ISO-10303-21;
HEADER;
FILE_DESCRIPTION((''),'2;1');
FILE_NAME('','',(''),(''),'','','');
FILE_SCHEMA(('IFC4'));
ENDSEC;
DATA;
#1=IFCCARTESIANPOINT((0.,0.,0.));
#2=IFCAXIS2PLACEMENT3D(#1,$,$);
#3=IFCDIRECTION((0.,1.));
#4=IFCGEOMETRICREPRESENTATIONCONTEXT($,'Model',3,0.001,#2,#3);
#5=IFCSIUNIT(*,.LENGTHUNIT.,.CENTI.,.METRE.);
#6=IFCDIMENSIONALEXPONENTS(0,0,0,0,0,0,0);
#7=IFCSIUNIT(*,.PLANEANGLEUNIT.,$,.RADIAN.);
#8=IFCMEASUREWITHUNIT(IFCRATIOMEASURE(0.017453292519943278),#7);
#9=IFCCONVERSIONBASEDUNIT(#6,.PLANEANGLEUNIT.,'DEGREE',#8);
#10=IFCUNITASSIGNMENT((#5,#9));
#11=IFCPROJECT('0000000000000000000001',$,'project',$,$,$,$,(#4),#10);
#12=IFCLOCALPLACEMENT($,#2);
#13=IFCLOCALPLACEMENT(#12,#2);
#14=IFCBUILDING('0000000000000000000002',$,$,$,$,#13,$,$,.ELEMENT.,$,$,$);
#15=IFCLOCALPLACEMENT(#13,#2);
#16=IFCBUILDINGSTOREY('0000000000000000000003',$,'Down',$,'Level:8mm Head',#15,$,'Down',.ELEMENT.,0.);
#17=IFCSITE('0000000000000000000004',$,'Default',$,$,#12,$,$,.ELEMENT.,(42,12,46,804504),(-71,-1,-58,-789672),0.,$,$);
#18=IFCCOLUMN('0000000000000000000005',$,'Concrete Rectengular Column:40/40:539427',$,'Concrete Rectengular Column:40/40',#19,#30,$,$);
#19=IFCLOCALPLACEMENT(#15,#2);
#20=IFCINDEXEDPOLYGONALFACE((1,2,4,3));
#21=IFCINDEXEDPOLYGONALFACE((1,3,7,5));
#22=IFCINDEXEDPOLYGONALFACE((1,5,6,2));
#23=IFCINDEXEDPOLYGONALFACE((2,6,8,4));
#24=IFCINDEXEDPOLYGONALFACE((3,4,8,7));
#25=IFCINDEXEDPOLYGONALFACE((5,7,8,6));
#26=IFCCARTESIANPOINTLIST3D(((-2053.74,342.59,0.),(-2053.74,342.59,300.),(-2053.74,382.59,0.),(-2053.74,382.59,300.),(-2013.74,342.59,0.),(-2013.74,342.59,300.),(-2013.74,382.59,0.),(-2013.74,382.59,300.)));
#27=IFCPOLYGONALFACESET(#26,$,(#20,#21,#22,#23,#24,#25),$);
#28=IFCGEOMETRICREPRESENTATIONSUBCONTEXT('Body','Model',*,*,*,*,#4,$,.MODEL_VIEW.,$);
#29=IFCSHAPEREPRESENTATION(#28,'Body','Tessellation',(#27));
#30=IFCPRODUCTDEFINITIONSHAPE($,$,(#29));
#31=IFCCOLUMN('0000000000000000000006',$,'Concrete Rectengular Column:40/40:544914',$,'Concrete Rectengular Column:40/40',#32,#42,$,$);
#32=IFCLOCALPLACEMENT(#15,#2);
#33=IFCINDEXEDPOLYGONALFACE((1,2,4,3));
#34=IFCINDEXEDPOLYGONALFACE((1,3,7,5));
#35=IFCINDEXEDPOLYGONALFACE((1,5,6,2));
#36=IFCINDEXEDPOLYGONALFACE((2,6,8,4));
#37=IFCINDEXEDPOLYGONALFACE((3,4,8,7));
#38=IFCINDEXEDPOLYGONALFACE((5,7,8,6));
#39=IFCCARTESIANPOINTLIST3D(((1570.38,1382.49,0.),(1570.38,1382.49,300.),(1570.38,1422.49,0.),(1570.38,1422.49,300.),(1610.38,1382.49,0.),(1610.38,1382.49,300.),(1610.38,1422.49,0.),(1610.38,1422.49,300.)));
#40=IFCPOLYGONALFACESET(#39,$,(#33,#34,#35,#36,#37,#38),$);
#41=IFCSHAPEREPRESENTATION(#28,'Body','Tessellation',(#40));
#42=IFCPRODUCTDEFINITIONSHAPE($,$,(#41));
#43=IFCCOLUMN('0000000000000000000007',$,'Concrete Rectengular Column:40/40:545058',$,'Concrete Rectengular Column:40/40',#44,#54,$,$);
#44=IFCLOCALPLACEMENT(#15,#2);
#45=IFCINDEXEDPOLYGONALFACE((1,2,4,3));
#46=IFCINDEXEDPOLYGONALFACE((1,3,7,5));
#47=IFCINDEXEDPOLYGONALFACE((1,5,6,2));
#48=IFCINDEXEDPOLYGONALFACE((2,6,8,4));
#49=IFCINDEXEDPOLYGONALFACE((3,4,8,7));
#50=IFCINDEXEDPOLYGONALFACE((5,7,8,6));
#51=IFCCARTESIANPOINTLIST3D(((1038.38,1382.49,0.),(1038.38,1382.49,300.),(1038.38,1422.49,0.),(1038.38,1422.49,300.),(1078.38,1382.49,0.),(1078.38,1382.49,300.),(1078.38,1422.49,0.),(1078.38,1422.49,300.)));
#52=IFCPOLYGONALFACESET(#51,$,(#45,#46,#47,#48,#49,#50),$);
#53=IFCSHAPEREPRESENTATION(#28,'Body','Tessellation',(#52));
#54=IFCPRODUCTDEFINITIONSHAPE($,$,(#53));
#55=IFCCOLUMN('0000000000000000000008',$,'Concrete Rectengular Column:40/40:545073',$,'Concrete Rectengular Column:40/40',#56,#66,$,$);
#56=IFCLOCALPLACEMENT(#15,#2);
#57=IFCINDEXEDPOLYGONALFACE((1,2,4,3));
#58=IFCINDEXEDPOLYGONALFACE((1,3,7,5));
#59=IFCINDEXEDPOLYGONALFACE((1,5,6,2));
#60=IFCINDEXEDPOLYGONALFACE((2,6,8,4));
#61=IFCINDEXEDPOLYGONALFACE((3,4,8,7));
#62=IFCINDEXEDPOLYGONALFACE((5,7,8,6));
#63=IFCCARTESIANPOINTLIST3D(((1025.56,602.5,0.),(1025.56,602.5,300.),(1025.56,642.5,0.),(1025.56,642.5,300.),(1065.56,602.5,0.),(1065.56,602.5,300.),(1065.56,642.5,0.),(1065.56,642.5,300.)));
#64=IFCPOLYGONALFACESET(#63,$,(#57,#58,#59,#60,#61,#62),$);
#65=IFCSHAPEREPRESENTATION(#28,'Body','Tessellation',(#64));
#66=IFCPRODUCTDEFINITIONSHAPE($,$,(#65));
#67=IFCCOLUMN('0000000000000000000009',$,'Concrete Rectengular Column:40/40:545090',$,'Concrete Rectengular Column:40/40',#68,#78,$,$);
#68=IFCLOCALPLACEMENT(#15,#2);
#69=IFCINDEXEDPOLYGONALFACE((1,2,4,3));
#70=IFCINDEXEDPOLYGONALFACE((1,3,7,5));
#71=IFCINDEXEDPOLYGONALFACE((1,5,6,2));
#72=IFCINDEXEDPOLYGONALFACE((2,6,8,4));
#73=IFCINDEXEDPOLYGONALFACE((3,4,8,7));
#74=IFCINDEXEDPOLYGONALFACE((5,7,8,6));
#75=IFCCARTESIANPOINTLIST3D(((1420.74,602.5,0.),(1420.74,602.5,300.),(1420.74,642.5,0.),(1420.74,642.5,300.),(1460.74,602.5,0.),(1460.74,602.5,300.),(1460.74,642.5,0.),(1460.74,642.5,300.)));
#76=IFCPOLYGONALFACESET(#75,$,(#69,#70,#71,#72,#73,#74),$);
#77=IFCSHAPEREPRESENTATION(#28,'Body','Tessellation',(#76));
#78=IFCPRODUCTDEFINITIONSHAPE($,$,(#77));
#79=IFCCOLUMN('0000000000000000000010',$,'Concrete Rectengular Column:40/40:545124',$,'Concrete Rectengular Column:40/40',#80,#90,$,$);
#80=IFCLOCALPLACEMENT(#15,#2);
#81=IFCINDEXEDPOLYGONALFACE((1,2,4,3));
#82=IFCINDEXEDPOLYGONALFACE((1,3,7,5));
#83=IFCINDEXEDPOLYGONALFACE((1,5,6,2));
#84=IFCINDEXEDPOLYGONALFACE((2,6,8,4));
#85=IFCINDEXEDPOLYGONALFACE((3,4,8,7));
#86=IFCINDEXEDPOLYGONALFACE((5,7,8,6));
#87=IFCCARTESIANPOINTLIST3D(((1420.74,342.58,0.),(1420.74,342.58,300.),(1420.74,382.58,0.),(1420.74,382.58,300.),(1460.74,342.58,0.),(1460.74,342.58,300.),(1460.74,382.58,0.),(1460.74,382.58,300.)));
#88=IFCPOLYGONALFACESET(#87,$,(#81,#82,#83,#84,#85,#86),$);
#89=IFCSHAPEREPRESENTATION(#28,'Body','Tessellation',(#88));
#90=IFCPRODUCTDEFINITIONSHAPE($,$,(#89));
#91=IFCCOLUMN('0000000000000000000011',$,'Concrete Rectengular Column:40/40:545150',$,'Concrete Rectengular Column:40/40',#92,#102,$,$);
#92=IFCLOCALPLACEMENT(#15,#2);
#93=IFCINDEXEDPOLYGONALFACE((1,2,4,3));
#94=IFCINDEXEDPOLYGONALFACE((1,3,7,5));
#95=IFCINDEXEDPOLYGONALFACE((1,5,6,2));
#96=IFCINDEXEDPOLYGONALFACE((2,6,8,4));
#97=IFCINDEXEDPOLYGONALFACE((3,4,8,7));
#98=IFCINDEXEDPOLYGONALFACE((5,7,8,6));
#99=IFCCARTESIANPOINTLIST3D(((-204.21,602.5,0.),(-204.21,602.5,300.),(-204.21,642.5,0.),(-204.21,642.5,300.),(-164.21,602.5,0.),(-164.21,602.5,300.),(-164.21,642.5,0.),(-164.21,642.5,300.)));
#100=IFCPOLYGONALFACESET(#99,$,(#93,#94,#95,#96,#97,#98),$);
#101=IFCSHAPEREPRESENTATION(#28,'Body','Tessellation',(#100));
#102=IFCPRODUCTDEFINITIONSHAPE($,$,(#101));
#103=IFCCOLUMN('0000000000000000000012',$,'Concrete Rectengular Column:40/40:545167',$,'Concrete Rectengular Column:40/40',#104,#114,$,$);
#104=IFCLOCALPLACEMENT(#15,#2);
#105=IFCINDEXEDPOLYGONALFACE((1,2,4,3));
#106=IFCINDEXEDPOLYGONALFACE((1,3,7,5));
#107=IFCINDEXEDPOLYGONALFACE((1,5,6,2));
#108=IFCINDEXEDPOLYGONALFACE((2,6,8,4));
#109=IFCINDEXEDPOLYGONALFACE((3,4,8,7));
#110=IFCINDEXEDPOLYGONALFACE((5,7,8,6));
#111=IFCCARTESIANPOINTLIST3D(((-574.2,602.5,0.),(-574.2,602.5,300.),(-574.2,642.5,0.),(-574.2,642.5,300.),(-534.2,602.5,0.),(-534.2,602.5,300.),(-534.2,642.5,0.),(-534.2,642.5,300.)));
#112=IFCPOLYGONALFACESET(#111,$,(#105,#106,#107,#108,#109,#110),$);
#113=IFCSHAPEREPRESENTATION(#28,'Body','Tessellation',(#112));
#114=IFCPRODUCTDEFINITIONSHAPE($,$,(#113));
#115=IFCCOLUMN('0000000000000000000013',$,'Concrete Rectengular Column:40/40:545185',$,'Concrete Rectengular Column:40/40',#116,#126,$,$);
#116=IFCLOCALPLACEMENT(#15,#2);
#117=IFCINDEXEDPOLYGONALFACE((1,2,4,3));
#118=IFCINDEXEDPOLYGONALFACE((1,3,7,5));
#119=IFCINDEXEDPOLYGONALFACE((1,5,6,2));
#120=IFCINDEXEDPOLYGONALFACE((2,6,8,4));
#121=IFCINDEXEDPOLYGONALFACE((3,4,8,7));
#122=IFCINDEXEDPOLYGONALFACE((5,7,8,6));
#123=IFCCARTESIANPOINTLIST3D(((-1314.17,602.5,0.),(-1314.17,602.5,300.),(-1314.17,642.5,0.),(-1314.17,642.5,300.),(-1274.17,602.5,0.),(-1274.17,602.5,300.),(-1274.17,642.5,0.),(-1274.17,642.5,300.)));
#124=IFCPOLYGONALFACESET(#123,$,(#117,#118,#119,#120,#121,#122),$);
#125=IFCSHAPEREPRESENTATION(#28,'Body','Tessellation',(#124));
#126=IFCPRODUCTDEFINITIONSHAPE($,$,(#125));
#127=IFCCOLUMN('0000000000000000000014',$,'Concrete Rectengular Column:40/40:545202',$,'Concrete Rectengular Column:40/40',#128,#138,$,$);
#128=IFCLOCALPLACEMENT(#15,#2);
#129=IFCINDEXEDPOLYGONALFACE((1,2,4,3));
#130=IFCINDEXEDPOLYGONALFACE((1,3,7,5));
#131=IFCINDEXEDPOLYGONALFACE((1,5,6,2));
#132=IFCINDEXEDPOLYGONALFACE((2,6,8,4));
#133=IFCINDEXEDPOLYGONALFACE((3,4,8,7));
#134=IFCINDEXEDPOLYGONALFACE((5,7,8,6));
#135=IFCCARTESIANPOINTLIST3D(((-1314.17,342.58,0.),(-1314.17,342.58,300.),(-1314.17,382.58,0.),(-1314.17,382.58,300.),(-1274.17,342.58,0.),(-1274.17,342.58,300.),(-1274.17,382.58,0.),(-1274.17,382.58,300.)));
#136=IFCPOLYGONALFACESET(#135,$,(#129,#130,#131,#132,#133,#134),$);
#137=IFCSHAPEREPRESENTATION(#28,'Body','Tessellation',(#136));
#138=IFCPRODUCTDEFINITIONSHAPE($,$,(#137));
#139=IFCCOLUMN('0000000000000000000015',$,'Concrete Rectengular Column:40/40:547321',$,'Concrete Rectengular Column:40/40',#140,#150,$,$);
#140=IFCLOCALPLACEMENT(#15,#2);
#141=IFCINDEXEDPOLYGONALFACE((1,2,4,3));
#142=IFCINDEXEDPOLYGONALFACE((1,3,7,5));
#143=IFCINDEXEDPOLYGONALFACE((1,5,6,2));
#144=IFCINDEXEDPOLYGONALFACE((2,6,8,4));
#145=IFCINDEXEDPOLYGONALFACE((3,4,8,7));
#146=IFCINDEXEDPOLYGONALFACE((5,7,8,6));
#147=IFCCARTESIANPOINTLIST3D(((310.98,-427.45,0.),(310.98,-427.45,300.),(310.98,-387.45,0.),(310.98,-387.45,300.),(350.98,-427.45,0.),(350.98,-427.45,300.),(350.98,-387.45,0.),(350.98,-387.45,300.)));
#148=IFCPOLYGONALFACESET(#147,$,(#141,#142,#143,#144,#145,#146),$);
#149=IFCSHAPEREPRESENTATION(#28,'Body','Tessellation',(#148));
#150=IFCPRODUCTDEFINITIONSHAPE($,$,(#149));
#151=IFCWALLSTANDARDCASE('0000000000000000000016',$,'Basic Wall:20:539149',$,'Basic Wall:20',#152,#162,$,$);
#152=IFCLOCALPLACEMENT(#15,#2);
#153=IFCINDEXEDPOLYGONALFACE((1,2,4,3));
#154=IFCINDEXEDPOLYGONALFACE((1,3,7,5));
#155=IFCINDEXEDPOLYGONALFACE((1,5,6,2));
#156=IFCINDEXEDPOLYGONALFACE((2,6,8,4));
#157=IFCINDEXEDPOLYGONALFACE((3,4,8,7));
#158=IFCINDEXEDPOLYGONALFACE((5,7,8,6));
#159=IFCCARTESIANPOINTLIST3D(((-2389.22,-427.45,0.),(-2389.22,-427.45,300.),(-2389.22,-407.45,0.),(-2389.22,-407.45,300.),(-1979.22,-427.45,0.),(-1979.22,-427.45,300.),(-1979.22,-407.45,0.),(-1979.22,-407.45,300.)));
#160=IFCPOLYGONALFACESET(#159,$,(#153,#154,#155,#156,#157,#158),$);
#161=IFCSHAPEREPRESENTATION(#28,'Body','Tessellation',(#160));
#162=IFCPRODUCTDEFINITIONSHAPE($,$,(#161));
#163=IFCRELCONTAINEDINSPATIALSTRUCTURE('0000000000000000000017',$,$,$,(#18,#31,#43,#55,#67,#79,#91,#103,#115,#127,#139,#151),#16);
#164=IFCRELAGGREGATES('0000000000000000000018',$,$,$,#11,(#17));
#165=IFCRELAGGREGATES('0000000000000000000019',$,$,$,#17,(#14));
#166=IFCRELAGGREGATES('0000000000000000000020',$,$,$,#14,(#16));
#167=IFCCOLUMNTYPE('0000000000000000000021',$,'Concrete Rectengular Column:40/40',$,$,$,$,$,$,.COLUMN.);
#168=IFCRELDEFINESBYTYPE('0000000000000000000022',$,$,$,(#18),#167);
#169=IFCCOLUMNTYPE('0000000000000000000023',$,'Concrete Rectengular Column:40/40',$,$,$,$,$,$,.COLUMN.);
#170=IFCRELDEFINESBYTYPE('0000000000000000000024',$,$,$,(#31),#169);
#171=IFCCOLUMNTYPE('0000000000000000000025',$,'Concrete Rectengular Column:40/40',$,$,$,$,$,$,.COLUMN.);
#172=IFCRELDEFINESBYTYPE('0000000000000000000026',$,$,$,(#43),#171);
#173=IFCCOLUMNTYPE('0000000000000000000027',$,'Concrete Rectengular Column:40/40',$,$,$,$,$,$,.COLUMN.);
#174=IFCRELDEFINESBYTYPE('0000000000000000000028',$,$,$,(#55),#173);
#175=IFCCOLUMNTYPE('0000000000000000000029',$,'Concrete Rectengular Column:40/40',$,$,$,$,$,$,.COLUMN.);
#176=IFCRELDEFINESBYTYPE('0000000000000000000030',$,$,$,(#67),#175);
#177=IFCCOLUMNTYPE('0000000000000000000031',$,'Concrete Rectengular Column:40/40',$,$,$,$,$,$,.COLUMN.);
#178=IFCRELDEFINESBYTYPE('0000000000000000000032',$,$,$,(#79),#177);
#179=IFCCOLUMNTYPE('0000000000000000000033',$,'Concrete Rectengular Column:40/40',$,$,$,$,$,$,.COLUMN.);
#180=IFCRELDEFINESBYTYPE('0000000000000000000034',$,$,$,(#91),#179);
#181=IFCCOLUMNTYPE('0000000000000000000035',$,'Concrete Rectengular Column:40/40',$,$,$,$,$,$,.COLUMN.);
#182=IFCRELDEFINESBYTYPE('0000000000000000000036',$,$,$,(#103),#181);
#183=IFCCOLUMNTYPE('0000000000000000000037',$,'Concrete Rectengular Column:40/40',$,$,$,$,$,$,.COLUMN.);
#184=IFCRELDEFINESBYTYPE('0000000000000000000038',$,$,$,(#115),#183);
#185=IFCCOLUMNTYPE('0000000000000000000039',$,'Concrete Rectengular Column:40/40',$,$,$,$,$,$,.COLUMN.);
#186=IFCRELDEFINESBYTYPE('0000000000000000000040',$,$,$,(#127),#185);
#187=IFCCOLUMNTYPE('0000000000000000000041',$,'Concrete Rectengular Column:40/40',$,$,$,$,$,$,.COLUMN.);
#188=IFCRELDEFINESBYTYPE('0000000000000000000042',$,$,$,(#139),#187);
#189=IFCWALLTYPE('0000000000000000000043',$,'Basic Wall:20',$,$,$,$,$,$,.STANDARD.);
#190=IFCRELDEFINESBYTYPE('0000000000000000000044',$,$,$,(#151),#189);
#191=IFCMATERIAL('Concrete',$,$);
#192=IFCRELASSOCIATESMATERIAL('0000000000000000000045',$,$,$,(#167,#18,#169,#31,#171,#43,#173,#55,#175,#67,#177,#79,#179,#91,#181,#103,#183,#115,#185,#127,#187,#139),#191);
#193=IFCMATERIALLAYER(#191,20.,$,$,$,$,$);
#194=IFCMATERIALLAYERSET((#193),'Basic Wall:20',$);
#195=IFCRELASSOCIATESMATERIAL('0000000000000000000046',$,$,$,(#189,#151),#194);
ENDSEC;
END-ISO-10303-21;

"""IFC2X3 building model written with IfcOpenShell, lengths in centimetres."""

from ifc_helpers import new_model, entity, si_unit, converted_unit, direction, frame, frame_2d, origin, origin_2d_with_axis, place, context, subcontext, project, spatial, rectangle, extrude, source, transform, mapped, material, layer, layer_set, layer_usage, type_object, type_shapes, element, save


model = new_model("IFC2X3")

# Units and contexts
model_context = context("Model", 3, precision=0.001, world=origin(), true_north=direction((0.0, 1.0)))
body_context = subcontext(model_context, "Body", "Model", "MODEL_VIEW")
ifc_project = project(units=[si_unit("LENGTHUNIT", "METRE", prefix="CENTI"), converted_unit("PLANEANGLEUNIT", "DEGREE", entity("IfcRatioMeasure", 0.017453292519943278), si_unit("PLANEANGLEUNIT", "RADIAN"), dimensions=[0, 0, 0, 0, 0, 0, 0])], contexts=[model_context])

# Site, building, storey
site_placement = place(None, origin())
site = spatial("IfcSite", under=ifc_project, at=site_placement, Name="Default", CompositionType="ELEMENT", RefLatitude=(42, 12, 46, 804504), RefLongitude=(-71, -1, -58, -789672), RefElevation=0.0)
building_placement = place(site_placement, origin())
building = spatial("IfcBuilding", under=site, at=building_placement, CompositionType="ELEMENT")
storey_placement = place(building_placement, origin())
storey = spatial("IfcBuildingStorey", under=building, at=storey_placement, Name="Down", ObjectType="Level:8mm Head", LongName="Down", CompositionType="ELEMENT", Elevation=0.0)

# Columns
ifc_material = material(Name="Concrete")
column_type_1 = type_object("IfcColumnType", Name="Concrete Rectengular Column:40/40", PredefinedType="COLUMN", material=ifc_material)
shared_shape_1 = source(origin(), body_context, "Body", "SweptSolid", [
    extrude(rectangle(XDim=40.0, YDim=40.0, at=frame_2d((0.0, 0.0), x_axis=(1.0, 0.0))), frame((-2033.74, 362.59, 0.0), z_axis=(0.0, 0.0, 1.0), x_axis=(0.0, -1.0, 0.0)), (0.0, 0.0, 1.0), 300.0),
])
type_shapes(column_type_1, [shared_shape_1])
column_1_placement = place(storey_placement, origin())
element("IfcColumn", 1, at=column_1_placement, inside=storey, type_object=column_type_1, material=ifc_material, Name="Concrete Rectengular Column:40/40:539427", ObjectType="Concrete Rectengular Column:40/40", context=body_context, shape_type="MappedRepresentation", body=[
    mapped(shared_shape_1, transform((0.0, 0.0, 0.0), scale=1.0)),
])
column_type_2 = type_object("IfcColumnType", Name="Concrete Rectengular Column:40/40", PredefinedType="COLUMN", material=ifc_material)
shared_shape_2 = source(origin(), body_context, "Body", "SweptSolid", [
    extrude(rectangle(XDim=40.0, YDim=40.0, at=origin_2d_with_axis()), frame((1590.38, 1402.49, 0.0), z_axis=(0.0, 0.0, 1.0), x_axis=(0.0, -1.0, 0.0)), (0.0, 0.0, 1.0), 300.0),
])
type_shapes(column_type_2, [shared_shape_2])
column_2_placement = place(storey_placement, origin())
element("IfcColumn", 2, at=column_2_placement, inside=storey, type_object=column_type_2, material=ifc_material, Name="Concrete Rectengular Column:40/40:544914", ObjectType="Concrete Rectengular Column:40/40", context=body_context, shape_type="MappedRepresentation", body=[
    mapped(shared_shape_2, transform((0.0, 0.0, 0.0), scale=1.0)),
])
column_type_3 = type_object("IfcColumnType", Name="Concrete Rectengular Column:40/40", PredefinedType="COLUMN", material=ifc_material)
shared_shape_3 = source(origin(), body_context, "Body", "SweptSolid", [
    extrude(rectangle(XDim=40.0, YDim=40.0, at=origin_2d_with_axis()), frame((1058.38, 1402.49, 0.0), z_axis=(0.0, 0.0, 1.0), x_axis=(0.0, -1.0, 0.0)), (0.0, 0.0, 1.0), 300.0),
])
type_shapes(column_type_3, [shared_shape_3])
column_3_placement = place(storey_placement, origin())
element("IfcColumn", 3, at=column_3_placement, inside=storey, type_object=column_type_3, material=ifc_material, Name="Concrete Rectengular Column:40/40:545058", ObjectType="Concrete Rectengular Column:40/40", context=body_context, shape_type="MappedRepresentation", body=[
    mapped(shared_shape_3, transform((0.0, 0.0, 0.0), scale=1.0)),
])
column_type_4 = type_object("IfcColumnType", Name="Concrete Rectengular Column:40/40", PredefinedType="COLUMN", material=ifc_material)
shared_shape_4 = source(origin(), body_context, "Body", "SweptSolid", [
    extrude(rectangle(XDim=40.0, YDim=40.0, at=origin_2d_with_axis()), frame((1045.56, 622.5, 0.0), z_axis=(0.0, 0.0, 1.0), x_axis=(0.0, -1.0, 0.0)), (0.0, 0.0, 1.0), 300.0),
])
type_shapes(column_type_4, [shared_shape_4])
column_4_placement = place(storey_placement, origin())
element("IfcColumn", 4, at=column_4_placement, inside=storey, type_object=column_type_4, material=ifc_material, Name="Concrete Rectengular Column:40/40:545073", ObjectType="Concrete Rectengular Column:40/40", context=body_context, shape_type="MappedRepresentation", body=[
    mapped(shared_shape_4, transform((0.0, 0.0, 0.0), scale=1.0)),
])
column_type_5 = type_object("IfcColumnType", Name="Concrete Rectengular Column:40/40", PredefinedType="COLUMN", material=ifc_material)
shared_shape_5 = source(origin(), body_context, "Body", "SweptSolid", [
    extrude(rectangle(XDim=40.0, YDim=40.0, at=origin_2d_with_axis()), frame((1440.74, 622.5, 0.0), z_axis=(0.0, 0.0, 1.0), x_axis=(0.0, -1.0, 0.0)), (0.0, 0.0, 1.0), 300.0),
])
type_shapes(column_type_5, [shared_shape_5])
column_5_placement = place(storey_placement, origin())
element("IfcColumn", 5, at=column_5_placement, inside=storey, type_object=column_type_5, material=ifc_material, Name="Concrete Rectengular Column:40/40:545090", ObjectType="Concrete Rectengular Column:40/40", context=body_context, shape_type="MappedRepresentation", body=[
    mapped(shared_shape_5, transform((0.0, 0.0, 0.0), scale=1.0)),
])
column_type_6 = type_object("IfcColumnType", Name="Concrete Rectengular Column:40/40", PredefinedType="COLUMN", material=ifc_material)
shared_shape_6 = source(origin(), body_context, "Body", "SweptSolid", [
    extrude(rectangle(XDim=40.0, YDim=40.0, at=frame_2d((0.0, 0.0), x_axis=(1.0, 0.0))), frame((1440.74, 362.58, 0.0), z_axis=(0.0, 0.0, 1.0), x_axis=(0.0, -1.0, 0.0)), (0.0, 0.0, 1.0), 300.0),
])
type_shapes(column_type_6, [shared_shape_6])
column_6_placement = place(storey_placement, origin())
element("IfcColumn", 6, at=column_6_placement, inside=storey, type_object=column_type_6, material=ifc_material, Name="Concrete Rectengular Column:40/40:545124", ObjectType="Concrete Rectengular Column:40/40", context=body_context, shape_type="MappedRepresentation", body=[
    mapped(shared_shape_6, transform((0.0, 0.0, 0.0), scale=1.0)),
])
column_type_7 = type_object("IfcColumnType", Name="Concrete Rectengular Column:40/40", PredefinedType="COLUMN", material=ifc_material)
shared_shape_7 = source(origin(), body_context, "Body", "SweptSolid", [
    extrude(rectangle(XDim=40.0, YDim=40.0, at=frame_2d((0.0, 0.0), x_axis=(1.0, 0.0))), frame((-184.21, 622.5, 0.0), z_axis=(0.0, 0.0, 1.0), x_axis=(0.0, -1.0, 0.0)), (0.0, 0.0, 1.0), 300.0),
])
type_shapes(column_type_7, [shared_shape_7])
column_7_placement = place(storey_placement, origin())
element("IfcColumn", 7, at=column_7_placement, inside=storey, type_object=column_type_7, material=ifc_material, Name="Concrete Rectengular Column:40/40:545150", ObjectType="Concrete Rectengular Column:40/40", context=body_context, shape_type="MappedRepresentation", body=[
    mapped(shared_shape_7, transform((0.0, 0.0, 0.0), scale=1.0)),
])
column_type_8 = type_object("IfcColumnType", Name="Concrete Rectengular Column:40/40", PredefinedType="COLUMN", material=ifc_material)
shared_shape_8 = source(origin(), body_context, "Body", "SweptSolid", [
    extrude(rectangle(XDim=40.0, YDim=40.0, at=origin_2d_with_axis()), frame((-554.2, 622.5, 0.0), z_axis=(0.0, 0.0, 1.0), x_axis=(0.0, -1.0, 0.0)), (0.0, 0.0, 1.0), 300.0),
])
type_shapes(column_type_8, [shared_shape_8])
column_8_placement = place(storey_placement, origin())
element("IfcColumn", 8, at=column_8_placement, inside=storey, type_object=column_type_8, material=ifc_material, Name="Concrete Rectengular Column:40/40:545167", ObjectType="Concrete Rectengular Column:40/40", context=body_context, shape_type="MappedRepresentation", body=[
    mapped(shared_shape_8, transform((0.0, 0.0, 0.0), scale=1.0)),
])
column_type_9 = type_object("IfcColumnType", Name="Concrete Rectengular Column:40/40", PredefinedType="COLUMN", material=ifc_material)
shared_shape_9 = source(origin(), body_context, "Body", "SweptSolid", [
    extrude(rectangle(XDim=40.0, YDim=40.0, at=origin_2d_with_axis()), frame((-1294.17, 622.5, 0.0), z_axis=(0.0, 0.0, 1.0), x_axis=(0.0, -1.0, 0.0)), (0.0, 0.0, 1.0), 300.0),
])
type_shapes(column_type_9, [shared_shape_9])
column_9_placement = place(storey_placement, origin())
element("IfcColumn", 9, at=column_9_placement, inside=storey, type_object=column_type_9, material=ifc_material, Name="Concrete Rectengular Column:40/40:545185", ObjectType="Concrete Rectengular Column:40/40", context=body_context, shape_type="MappedRepresentation", body=[
    mapped(shared_shape_9, transform((0.0, 0.0, 0.0), scale=1.0)),
])
column_type_10 = type_object("IfcColumnType", Name="Concrete Rectengular Column:40/40", PredefinedType="COLUMN", material=ifc_material)
shared_shape_10 = source(origin(), body_context, "Body", "SweptSolid", [
    extrude(rectangle(XDim=40.0, YDim=40.0, at=origin_2d_with_axis()), frame((-1294.17, 362.58, 0.0), z_axis=(0.0, 0.0, 1.0), x_axis=(0.0, -1.0, 0.0)), (0.0, 0.0, 1.0), 300.0),
])
type_shapes(column_type_10, [shared_shape_10])
column_10_placement = place(storey_placement, origin())
element("IfcColumn", 10, at=column_10_placement, inside=storey, type_object=column_type_10, material=ifc_material, Name="Concrete Rectengular Column:40/40:545202", ObjectType="Concrete Rectengular Column:40/40", context=body_context, shape_type="MappedRepresentation", body=[
    mapped(shared_shape_10, transform((0.0, 0.0, 0.0), scale=1.0)),
])
column_type_11 = type_object("IfcColumnType", Name="Concrete Rectengular Column:40/40", PredefinedType="COLUMN", material=ifc_material)
shared_shape_11 = source(origin(), body_context, "Body", "SweptSolid", [
    extrude(rectangle(XDim=40.0, YDim=40.0, at=origin_2d_with_axis()), frame((330.98, -407.45, 0.0), z_axis=(0.0, 0.0, 1.0), x_axis=(0.0, -1.0, 0.0)), (0.0, 0.0, 1.0), 300.0),
])
type_shapes(column_type_11, [shared_shape_11])
column_11_placement = place(storey_placement, origin())
element("IfcColumn", 11, at=column_11_placement, inside=storey, type_object=column_type_11, material=ifc_material, Name="Concrete Rectengular Column:40/40:547321", ObjectType="Concrete Rectengular Column:40/40", context=body_context, shape_type="MappedRepresentation", body=[
    mapped(shared_shape_11, transform((0.0, 0.0, 0.0), scale=1.0)),
])

# Wall
ifc_layer_1 = layer(ifc_material, 20.0)
ifc_layer_set_1 = layer_set([ifc_layer_1], Name="Basic Wall:20")
ifc_layer_usage_1 = layer_usage(ifc_layer_set_1, "AXIS2", "NEGATIVE", 10.0)
wall_type_1 = type_object("IfcWallType", Name="Basic Wall:20", PredefinedType="STANDARD", material=ifc_layer_set_1)
wall_1_placement = place(storey_placement, frame((-1979.22, -417.45, 0.0), z_axis=(0.0, 0.0, 1.0), x_axis=(-1.0, 0.0, 0.0)))
element("IfcWallStandardCase", 12, at=wall_1_placement, inside=storey, type_object=wall_type_1, material=ifc_layer_usage_1, Name="Basic Wall:20:539149", ObjectType="Basic Wall:20", context=body_context, shape_type="SweptSolid", body=[
    extrude(rectangle(XDim=409.99, YDim=20.0, at=frame_2d((205.0, 0.0), x_axis=(-1.0, 0.0))), origin(), (0.0, 0.0, 1.0), 300.0),
])

save(model, "model.ifc")
